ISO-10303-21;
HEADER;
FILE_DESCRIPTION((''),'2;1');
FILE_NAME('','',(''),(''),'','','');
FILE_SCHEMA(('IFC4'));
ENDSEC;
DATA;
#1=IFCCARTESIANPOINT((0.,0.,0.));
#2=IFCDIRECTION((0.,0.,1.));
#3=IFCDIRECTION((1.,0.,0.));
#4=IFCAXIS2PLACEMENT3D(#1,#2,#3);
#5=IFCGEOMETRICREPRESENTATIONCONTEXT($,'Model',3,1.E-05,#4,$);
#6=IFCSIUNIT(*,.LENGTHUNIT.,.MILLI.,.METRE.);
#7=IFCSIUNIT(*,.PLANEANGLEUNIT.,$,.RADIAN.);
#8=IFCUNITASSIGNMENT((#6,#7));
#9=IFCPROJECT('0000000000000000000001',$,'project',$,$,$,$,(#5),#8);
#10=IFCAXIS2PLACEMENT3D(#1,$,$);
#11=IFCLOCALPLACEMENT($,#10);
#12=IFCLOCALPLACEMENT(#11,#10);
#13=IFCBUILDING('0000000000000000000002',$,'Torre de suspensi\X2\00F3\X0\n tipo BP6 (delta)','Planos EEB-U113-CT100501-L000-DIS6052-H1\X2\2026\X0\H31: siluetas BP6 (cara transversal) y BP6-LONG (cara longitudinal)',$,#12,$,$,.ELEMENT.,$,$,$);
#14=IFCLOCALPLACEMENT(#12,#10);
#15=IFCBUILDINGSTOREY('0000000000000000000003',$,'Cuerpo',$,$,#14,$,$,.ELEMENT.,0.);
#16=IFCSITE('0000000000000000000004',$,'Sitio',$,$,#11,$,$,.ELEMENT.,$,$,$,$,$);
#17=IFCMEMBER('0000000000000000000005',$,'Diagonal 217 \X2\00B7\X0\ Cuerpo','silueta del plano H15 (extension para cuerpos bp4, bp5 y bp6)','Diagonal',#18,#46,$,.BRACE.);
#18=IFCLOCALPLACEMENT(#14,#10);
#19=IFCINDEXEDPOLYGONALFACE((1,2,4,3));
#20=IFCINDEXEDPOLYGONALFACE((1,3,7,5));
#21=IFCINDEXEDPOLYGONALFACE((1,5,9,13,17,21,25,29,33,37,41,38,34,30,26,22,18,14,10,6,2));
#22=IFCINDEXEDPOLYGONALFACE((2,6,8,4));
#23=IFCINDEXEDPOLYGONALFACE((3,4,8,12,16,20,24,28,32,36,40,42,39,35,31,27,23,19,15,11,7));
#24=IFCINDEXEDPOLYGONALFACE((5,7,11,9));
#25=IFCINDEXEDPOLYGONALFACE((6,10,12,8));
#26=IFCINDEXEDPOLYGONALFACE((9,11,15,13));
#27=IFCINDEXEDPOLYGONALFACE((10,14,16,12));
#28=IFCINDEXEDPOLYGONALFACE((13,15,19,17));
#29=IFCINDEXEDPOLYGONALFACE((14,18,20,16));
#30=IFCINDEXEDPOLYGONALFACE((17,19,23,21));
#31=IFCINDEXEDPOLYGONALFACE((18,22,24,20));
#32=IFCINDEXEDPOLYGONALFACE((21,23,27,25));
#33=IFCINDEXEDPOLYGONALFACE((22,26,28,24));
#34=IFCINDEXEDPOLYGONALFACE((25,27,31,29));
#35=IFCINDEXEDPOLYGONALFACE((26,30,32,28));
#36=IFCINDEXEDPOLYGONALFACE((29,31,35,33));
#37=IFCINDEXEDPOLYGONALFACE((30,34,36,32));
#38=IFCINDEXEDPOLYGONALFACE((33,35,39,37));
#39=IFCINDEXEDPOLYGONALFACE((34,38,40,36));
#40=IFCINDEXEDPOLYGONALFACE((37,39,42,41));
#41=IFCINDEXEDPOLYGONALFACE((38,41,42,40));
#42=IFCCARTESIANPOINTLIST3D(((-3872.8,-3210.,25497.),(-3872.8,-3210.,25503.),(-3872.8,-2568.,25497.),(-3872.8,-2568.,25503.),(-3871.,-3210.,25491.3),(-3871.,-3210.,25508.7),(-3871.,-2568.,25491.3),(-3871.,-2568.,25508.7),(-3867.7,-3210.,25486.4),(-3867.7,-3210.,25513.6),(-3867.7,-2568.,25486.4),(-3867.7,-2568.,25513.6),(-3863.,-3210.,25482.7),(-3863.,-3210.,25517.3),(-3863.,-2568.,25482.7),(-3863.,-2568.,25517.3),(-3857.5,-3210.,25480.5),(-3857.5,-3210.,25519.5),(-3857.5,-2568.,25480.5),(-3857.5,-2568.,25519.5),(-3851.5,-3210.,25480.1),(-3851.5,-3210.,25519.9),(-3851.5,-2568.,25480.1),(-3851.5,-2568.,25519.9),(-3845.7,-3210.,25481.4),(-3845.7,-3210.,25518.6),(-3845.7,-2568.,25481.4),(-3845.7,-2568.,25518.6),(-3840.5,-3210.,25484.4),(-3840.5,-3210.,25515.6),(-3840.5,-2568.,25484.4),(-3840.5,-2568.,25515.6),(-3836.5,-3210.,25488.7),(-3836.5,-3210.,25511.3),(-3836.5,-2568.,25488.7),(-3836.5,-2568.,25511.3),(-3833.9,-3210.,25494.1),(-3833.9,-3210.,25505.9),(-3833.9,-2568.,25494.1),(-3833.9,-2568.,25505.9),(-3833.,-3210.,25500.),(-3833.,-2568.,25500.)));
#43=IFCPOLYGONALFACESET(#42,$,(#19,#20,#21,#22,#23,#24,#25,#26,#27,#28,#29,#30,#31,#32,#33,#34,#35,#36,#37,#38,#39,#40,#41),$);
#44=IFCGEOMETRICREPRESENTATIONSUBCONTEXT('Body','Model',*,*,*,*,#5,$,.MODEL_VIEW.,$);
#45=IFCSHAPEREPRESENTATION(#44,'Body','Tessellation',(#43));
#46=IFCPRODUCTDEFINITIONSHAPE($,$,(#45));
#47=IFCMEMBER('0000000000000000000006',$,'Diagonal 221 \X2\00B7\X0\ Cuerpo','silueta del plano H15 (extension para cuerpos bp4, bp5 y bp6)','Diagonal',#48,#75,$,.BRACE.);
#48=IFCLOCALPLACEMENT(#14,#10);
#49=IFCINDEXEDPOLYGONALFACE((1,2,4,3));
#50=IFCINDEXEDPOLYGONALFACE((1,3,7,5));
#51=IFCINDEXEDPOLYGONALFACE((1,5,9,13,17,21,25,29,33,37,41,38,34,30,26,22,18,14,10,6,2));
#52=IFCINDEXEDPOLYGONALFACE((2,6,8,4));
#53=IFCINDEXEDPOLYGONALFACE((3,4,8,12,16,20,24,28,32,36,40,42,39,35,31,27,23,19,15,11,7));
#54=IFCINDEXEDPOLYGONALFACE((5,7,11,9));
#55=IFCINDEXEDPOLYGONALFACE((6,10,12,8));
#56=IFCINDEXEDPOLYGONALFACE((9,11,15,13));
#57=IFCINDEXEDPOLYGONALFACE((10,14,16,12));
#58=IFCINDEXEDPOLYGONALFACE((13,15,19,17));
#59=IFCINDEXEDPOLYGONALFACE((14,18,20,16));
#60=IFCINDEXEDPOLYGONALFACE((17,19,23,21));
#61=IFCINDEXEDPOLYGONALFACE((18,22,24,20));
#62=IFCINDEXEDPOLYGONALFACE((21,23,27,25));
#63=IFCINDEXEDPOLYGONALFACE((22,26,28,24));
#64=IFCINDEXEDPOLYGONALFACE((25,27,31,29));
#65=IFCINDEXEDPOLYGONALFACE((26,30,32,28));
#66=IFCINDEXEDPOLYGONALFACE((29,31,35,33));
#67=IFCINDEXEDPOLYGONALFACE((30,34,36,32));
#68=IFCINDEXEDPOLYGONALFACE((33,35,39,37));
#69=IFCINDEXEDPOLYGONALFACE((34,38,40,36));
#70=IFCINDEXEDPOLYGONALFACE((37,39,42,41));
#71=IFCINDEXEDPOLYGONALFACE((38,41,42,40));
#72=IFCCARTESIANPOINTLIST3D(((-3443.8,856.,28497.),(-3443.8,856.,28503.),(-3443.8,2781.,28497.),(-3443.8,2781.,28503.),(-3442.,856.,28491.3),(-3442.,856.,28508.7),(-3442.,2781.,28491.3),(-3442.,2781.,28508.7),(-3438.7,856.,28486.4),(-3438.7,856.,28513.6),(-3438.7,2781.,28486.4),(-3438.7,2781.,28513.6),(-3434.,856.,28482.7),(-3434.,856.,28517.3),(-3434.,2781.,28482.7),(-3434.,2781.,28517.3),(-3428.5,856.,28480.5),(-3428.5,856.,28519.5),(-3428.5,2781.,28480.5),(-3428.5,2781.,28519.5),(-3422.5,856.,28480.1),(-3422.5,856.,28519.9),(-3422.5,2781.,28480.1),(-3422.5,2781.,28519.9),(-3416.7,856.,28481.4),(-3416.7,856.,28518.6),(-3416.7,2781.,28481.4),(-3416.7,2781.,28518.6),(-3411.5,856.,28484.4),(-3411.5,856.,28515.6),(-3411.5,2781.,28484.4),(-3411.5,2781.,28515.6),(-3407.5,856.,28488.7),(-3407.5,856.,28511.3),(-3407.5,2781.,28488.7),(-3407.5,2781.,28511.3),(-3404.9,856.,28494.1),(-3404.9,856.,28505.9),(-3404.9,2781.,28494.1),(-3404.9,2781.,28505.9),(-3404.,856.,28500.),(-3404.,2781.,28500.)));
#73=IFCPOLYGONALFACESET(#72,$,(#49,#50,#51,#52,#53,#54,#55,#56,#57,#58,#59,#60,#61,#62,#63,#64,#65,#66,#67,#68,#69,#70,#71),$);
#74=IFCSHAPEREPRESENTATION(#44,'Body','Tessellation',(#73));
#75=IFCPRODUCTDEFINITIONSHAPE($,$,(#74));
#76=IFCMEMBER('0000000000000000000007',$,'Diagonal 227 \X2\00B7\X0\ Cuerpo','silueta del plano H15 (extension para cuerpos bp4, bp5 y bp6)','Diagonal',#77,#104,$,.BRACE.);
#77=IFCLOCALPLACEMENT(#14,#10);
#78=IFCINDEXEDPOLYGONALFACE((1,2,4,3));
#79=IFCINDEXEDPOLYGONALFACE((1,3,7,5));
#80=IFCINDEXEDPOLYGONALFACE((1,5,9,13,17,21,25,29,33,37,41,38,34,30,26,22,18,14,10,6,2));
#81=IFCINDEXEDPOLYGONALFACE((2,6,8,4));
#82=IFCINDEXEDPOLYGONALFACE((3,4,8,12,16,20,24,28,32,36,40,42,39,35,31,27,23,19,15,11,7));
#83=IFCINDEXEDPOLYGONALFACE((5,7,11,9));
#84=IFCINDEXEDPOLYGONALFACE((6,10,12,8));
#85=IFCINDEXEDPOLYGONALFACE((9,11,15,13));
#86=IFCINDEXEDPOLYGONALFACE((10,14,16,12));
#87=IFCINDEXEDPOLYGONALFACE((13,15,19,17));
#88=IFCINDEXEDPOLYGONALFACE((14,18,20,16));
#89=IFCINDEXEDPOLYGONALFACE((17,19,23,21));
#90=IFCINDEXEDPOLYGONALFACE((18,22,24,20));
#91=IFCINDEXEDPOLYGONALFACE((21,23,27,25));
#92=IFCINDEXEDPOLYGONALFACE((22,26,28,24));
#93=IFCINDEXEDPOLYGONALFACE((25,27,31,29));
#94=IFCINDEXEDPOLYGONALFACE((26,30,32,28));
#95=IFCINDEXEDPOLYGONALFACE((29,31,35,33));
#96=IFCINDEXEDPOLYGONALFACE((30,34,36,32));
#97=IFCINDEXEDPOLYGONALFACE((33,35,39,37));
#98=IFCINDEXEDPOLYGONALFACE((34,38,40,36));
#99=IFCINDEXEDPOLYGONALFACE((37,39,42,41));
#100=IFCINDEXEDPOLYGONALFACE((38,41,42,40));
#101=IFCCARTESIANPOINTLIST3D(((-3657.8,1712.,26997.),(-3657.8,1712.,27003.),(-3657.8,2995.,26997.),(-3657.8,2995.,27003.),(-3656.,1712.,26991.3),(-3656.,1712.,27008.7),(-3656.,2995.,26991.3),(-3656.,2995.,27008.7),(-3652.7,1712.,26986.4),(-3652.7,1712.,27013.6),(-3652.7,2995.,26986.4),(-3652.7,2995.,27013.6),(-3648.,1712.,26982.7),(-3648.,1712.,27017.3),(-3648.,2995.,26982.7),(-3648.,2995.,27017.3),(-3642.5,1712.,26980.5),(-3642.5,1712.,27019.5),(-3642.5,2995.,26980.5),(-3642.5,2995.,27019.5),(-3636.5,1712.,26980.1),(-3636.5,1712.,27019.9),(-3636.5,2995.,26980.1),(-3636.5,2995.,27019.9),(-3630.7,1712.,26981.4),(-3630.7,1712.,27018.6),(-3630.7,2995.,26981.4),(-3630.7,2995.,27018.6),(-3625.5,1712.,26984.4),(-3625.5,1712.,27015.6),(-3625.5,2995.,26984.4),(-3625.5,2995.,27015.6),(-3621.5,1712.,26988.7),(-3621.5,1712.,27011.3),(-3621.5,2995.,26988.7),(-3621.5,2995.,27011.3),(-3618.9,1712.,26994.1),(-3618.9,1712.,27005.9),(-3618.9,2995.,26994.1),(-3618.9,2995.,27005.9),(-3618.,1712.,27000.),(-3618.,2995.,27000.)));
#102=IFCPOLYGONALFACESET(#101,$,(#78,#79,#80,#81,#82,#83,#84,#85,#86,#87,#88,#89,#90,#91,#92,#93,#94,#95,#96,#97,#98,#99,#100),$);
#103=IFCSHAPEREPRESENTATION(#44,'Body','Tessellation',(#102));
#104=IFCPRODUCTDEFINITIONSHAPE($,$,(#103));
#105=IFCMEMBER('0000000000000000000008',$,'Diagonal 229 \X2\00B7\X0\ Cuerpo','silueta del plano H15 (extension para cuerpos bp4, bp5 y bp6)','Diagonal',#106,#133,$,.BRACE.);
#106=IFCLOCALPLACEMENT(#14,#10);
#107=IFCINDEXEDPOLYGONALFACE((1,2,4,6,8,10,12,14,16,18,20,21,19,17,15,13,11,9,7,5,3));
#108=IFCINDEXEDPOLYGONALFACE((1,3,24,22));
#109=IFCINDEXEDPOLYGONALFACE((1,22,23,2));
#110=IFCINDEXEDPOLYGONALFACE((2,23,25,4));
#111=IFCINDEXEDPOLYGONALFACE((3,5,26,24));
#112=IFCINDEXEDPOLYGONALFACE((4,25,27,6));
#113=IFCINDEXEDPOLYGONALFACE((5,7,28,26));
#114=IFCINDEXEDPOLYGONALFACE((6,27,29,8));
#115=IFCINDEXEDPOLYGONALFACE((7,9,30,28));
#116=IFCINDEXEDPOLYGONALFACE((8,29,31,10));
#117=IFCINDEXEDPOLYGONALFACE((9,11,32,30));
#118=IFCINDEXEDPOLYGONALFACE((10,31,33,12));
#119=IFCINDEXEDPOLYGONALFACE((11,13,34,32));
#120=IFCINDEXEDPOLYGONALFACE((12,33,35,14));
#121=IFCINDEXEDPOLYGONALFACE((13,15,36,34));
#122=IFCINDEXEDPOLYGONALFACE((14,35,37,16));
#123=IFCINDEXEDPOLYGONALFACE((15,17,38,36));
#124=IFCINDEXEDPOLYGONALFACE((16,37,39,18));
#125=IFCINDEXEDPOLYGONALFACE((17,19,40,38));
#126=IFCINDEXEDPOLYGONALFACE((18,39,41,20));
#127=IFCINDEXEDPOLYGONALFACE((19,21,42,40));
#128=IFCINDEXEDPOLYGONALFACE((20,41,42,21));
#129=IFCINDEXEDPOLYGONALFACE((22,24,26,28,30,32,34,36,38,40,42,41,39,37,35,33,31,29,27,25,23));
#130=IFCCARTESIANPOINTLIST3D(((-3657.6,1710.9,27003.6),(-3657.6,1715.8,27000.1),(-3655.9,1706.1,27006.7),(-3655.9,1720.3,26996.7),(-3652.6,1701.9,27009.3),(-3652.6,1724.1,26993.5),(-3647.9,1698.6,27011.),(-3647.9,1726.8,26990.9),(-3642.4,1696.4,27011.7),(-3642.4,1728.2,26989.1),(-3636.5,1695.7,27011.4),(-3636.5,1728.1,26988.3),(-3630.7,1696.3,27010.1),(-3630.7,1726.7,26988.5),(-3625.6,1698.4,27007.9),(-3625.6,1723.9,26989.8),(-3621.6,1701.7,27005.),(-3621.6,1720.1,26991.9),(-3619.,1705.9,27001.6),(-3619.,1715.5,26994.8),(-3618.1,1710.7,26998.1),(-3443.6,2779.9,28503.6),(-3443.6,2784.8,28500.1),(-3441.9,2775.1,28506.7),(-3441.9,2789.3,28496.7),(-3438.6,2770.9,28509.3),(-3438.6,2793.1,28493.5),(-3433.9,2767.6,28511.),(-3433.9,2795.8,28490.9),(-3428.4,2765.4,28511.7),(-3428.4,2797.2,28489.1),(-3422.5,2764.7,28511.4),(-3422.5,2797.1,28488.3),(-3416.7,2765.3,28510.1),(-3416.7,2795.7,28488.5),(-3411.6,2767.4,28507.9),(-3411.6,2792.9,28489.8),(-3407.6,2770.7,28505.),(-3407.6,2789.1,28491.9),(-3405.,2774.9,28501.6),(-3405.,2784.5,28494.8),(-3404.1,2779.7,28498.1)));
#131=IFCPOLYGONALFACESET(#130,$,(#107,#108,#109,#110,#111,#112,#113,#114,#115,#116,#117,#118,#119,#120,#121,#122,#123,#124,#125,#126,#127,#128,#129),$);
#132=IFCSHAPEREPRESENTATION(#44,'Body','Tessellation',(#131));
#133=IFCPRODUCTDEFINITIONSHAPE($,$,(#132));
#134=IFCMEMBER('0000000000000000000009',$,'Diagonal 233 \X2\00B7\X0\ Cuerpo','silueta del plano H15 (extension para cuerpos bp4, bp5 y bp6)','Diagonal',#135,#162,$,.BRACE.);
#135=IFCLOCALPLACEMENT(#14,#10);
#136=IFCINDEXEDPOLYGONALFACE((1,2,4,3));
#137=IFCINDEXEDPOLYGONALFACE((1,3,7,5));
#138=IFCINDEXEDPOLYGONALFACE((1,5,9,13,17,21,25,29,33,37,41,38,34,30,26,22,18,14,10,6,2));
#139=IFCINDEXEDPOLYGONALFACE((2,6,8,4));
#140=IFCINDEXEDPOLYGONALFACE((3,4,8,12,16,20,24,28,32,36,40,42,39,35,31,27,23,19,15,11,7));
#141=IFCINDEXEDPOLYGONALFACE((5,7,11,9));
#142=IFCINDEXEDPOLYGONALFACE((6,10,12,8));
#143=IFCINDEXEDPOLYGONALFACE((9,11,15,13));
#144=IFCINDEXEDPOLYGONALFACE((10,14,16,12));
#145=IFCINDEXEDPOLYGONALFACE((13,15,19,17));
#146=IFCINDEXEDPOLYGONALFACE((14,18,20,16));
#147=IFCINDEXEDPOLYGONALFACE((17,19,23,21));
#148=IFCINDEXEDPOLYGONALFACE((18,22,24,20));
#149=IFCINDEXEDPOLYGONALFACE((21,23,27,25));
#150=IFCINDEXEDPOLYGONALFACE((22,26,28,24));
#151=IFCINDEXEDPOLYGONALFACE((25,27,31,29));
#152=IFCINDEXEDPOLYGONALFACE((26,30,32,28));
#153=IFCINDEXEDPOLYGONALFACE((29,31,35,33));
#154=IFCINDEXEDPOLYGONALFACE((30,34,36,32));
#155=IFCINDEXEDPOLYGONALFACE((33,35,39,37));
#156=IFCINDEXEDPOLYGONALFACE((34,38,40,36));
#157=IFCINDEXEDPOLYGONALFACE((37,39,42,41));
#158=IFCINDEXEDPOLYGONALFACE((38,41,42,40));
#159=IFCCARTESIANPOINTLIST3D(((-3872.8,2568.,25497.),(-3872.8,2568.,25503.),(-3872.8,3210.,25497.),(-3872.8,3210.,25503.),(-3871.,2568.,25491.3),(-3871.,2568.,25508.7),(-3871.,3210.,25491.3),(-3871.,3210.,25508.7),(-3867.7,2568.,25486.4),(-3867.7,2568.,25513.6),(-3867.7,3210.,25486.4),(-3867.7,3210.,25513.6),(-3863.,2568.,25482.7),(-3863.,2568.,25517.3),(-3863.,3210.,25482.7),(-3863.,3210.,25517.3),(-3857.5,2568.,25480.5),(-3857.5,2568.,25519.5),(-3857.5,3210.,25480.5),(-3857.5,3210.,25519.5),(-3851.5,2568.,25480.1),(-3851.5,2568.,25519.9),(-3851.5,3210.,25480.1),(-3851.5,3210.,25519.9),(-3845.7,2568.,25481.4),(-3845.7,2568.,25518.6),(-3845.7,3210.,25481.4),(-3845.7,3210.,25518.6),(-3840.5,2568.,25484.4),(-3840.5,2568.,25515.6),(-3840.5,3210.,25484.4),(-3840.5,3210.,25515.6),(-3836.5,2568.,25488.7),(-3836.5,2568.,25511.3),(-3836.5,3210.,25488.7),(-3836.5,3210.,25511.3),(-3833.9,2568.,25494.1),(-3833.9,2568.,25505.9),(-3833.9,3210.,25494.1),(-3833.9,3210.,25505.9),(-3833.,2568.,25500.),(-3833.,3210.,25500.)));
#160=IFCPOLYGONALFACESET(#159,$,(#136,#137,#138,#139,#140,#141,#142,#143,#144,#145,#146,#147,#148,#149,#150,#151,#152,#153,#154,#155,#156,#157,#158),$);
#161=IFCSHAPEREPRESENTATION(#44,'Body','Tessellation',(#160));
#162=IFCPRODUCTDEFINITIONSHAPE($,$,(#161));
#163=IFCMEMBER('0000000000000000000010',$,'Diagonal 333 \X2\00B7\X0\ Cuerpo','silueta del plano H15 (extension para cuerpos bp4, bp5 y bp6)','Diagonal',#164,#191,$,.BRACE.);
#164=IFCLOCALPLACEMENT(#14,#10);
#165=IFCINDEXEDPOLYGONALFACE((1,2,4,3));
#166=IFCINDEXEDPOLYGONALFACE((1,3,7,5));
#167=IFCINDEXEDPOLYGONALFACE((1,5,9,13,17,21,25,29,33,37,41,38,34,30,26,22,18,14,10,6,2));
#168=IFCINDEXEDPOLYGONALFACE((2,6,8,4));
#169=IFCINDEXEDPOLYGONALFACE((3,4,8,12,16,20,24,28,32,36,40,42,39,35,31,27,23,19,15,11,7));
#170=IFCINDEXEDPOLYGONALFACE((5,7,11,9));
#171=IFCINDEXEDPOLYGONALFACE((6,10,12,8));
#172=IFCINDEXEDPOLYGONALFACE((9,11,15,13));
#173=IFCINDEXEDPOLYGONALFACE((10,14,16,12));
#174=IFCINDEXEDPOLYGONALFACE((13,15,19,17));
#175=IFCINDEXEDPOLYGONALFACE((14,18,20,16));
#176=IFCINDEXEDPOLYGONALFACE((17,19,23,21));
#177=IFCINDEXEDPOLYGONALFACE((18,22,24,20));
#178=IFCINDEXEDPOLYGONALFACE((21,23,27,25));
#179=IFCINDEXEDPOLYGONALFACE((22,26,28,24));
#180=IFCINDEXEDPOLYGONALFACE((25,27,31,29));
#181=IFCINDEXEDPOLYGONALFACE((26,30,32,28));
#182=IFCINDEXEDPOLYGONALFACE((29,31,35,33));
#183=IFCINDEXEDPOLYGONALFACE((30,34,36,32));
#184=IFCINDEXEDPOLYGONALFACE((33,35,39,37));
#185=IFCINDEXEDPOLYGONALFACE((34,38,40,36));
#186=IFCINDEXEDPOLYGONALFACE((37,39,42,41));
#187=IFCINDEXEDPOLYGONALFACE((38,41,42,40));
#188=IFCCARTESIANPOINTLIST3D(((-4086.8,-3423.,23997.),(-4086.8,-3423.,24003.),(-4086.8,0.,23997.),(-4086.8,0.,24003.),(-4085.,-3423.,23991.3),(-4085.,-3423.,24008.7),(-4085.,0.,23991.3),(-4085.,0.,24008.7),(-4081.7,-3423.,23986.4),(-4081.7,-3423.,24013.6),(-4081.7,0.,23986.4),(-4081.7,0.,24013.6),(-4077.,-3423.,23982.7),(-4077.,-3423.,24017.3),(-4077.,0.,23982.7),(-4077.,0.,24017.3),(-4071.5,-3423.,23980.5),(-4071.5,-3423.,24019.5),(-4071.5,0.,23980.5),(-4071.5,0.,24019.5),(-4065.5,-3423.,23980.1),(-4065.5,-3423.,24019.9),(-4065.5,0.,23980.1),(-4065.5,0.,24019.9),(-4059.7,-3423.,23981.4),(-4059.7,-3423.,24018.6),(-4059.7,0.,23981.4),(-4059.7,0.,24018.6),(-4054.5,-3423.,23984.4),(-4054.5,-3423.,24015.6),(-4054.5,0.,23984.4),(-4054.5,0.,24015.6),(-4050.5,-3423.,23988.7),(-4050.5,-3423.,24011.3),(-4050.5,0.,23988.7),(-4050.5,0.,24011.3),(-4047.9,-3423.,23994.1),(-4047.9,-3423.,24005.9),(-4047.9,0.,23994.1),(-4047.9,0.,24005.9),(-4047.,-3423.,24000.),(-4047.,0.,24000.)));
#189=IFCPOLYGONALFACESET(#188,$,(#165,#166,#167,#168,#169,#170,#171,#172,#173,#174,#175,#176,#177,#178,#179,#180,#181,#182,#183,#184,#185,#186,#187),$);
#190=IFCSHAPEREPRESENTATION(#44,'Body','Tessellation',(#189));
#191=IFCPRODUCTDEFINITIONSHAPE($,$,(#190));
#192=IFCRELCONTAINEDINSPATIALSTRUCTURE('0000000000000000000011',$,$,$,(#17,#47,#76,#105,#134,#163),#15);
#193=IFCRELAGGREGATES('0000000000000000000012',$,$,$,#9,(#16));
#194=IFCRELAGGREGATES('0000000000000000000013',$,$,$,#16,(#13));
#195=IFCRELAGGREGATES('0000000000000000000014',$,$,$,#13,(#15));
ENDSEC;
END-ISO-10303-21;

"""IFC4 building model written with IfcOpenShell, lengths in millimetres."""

from ifc_helpers import new_model, si_unit, frame, origin, origin_with_axes, place, context, subcontext, project, spatial, circle, extrude, element, save


model = new_model("IFC4")

# Units and contexts
model_context = context("Model", 3, precision=1e-05, world=origin_with_axes())
body_context = subcontext(model_context, "Body", "Model", "MODEL_VIEW")
ifc_project = project(units=[si_unit("LENGTHUNIT", "METRE", prefix="MILLI"), si_unit("PLANEANGLEUNIT", "RADIAN")], contexts=[model_context])

# Site, building, storey
site_placement = place(None, origin())
site = spatial("IfcSite", under=ifc_project, at=site_placement, Name="Sitio", CompositionType="ELEMENT")
building_placement = place(site_placement, origin())
building = spatial("IfcBuilding", under=site, at=building_placement, Name="Torre de suspensión tipo BP6 (delta)", Description="Planos EEB-U113-CT100501-L000-DIS6052-H1…H31: siluetas BP6 (cara transversal) y BP6-LONG (cara longitudinal)", CompositionType="ELEMENT")
storey_placement = place(building_placement, origin())
storey = spatial("IfcBuildingStorey", under=building, at=storey_placement, Name="Cuerpo", CompositionType="ELEMENT", Elevation=0.0)

# Members
member_1_placement = place(storey_placement, frame((-3853.0, -2568.0, 25500.0), z_axis=(0.0, -1.0, 0.0), x_axis=(1.0, 0.0, 0.0)))
element("IfcMember", 1, at=member_1_placement, inside=storey, Name="Diagonal 217 · Cuerpo", Description="silueta del plano H15 (extension para cuerpos bp4, bp5 y bp6)", ObjectType="Diagonal", PredefinedType="BRACE", context=body_context, shape_type="SweptSolid", body=[
    extrude(circle(Radius=20.0), None, (0.0, 0.0, 1.0), 642.0),
])
member_2_placement = place(storey_placement, frame((-3424.0, 856.0, 28500.0), z_axis=(0.0, 1.0, 0.0), x_axis=(1.0, 0.0, 0.0)))
element("IfcMember", 2, at=member_2_placement, inside=storey, Name="Diagonal 221 · Cuerpo", Description="silueta del plano H15 (extension para cuerpos bp4, bp5 y bp6)", ObjectType="Diagonal", PredefinedType="BRACE", context=body_context, shape_type="SweptSolid", body=[
    extrude(circle(Radius=20.0), None, (0.0, 0.0, 1.0), 1925.0),
])
member_3_placement = place(storey_placement, frame((-3638.0, 1712.0, 27000.0), z_axis=(0.0, 1.0, 0.0), x_axis=(1.0, 0.0, 0.0)))
element("IfcMember", 3, at=member_3_placement, inside=storey, Name="Diagonal 227 · Cuerpo", Description="silueta del plano H15 (extension para cuerpos bp4, bp5 y bp6)", ObjectType="Diagonal", PredefinedType="BRACE", context=body_context, shape_type="SweptSolid", body=[
    extrude(circle(Radius=20.0), None, (0.0, 0.0, 1.0), 1283.0),
])
member_4_placement = place(storey_placement, frame((-3638.0, 1712.0, 27000.0), z_axis=(0.115405, 0.576487, 0.808915), x_axis=(0.993318, -0.066977, -0.093981)))
element("IfcMember", 4, at=member_4_placement, inside=storey, Name="Diagonal 229 · Cuerpo", Description="silueta del plano H15 (extension para cuerpos bp4, bp5 y bp6)", ObjectType="Diagonal", PredefinedType="BRACE", context=body_context, shape_type="SweptSolid", body=[
    extrude(circle(Radius=20.0), None, (0.0, 0.0, 1.0), 1854.3),
])
member_5_placement = place(storey_placement, frame((-3853.0, 2568.0, 25500.0), z_axis=(0.0, 1.0, 0.0), x_axis=(1.0, 0.0, 0.0)))
element("IfcMember", 5, at=member_5_placement, inside=storey, Name="Diagonal 233 · Cuerpo", Description="silueta del plano H15 (extension para cuerpos bp4, bp5 y bp6)", ObjectType="Diagonal", PredefinedType="BRACE", context=body_context, shape_type="SweptSolid", body=[
    extrude(circle(Radius=20.0), None, (0.0, 0.0, 1.0), 642.0),
])
for number, where, z_axis, x_axis, name in (
    (6, (-4067.0, -3423.0, 24000.0), (0.0, 1.0, 0.0), (1.0, 0.0, 0.0), "Diagonal 333 · Cuerpo"),
):
    element("IfcMember", number, at=place(storey_placement, frame(where, z_axis=z_axis, x_axis=x_axis)), inside=storey, Name=name, Description="silueta del plano H15 (extension para cuerpos bp4, bp5 y bp6)", ObjectType="Diagonal", PredefinedType="BRACE", context=body_context, shape_type="SweptSolid", body=[
        extrude(circle(Radius=20.0), None, (0.0, 0.0, 1.0), 3423.0),
    ])

save(model, "model.ifc")
